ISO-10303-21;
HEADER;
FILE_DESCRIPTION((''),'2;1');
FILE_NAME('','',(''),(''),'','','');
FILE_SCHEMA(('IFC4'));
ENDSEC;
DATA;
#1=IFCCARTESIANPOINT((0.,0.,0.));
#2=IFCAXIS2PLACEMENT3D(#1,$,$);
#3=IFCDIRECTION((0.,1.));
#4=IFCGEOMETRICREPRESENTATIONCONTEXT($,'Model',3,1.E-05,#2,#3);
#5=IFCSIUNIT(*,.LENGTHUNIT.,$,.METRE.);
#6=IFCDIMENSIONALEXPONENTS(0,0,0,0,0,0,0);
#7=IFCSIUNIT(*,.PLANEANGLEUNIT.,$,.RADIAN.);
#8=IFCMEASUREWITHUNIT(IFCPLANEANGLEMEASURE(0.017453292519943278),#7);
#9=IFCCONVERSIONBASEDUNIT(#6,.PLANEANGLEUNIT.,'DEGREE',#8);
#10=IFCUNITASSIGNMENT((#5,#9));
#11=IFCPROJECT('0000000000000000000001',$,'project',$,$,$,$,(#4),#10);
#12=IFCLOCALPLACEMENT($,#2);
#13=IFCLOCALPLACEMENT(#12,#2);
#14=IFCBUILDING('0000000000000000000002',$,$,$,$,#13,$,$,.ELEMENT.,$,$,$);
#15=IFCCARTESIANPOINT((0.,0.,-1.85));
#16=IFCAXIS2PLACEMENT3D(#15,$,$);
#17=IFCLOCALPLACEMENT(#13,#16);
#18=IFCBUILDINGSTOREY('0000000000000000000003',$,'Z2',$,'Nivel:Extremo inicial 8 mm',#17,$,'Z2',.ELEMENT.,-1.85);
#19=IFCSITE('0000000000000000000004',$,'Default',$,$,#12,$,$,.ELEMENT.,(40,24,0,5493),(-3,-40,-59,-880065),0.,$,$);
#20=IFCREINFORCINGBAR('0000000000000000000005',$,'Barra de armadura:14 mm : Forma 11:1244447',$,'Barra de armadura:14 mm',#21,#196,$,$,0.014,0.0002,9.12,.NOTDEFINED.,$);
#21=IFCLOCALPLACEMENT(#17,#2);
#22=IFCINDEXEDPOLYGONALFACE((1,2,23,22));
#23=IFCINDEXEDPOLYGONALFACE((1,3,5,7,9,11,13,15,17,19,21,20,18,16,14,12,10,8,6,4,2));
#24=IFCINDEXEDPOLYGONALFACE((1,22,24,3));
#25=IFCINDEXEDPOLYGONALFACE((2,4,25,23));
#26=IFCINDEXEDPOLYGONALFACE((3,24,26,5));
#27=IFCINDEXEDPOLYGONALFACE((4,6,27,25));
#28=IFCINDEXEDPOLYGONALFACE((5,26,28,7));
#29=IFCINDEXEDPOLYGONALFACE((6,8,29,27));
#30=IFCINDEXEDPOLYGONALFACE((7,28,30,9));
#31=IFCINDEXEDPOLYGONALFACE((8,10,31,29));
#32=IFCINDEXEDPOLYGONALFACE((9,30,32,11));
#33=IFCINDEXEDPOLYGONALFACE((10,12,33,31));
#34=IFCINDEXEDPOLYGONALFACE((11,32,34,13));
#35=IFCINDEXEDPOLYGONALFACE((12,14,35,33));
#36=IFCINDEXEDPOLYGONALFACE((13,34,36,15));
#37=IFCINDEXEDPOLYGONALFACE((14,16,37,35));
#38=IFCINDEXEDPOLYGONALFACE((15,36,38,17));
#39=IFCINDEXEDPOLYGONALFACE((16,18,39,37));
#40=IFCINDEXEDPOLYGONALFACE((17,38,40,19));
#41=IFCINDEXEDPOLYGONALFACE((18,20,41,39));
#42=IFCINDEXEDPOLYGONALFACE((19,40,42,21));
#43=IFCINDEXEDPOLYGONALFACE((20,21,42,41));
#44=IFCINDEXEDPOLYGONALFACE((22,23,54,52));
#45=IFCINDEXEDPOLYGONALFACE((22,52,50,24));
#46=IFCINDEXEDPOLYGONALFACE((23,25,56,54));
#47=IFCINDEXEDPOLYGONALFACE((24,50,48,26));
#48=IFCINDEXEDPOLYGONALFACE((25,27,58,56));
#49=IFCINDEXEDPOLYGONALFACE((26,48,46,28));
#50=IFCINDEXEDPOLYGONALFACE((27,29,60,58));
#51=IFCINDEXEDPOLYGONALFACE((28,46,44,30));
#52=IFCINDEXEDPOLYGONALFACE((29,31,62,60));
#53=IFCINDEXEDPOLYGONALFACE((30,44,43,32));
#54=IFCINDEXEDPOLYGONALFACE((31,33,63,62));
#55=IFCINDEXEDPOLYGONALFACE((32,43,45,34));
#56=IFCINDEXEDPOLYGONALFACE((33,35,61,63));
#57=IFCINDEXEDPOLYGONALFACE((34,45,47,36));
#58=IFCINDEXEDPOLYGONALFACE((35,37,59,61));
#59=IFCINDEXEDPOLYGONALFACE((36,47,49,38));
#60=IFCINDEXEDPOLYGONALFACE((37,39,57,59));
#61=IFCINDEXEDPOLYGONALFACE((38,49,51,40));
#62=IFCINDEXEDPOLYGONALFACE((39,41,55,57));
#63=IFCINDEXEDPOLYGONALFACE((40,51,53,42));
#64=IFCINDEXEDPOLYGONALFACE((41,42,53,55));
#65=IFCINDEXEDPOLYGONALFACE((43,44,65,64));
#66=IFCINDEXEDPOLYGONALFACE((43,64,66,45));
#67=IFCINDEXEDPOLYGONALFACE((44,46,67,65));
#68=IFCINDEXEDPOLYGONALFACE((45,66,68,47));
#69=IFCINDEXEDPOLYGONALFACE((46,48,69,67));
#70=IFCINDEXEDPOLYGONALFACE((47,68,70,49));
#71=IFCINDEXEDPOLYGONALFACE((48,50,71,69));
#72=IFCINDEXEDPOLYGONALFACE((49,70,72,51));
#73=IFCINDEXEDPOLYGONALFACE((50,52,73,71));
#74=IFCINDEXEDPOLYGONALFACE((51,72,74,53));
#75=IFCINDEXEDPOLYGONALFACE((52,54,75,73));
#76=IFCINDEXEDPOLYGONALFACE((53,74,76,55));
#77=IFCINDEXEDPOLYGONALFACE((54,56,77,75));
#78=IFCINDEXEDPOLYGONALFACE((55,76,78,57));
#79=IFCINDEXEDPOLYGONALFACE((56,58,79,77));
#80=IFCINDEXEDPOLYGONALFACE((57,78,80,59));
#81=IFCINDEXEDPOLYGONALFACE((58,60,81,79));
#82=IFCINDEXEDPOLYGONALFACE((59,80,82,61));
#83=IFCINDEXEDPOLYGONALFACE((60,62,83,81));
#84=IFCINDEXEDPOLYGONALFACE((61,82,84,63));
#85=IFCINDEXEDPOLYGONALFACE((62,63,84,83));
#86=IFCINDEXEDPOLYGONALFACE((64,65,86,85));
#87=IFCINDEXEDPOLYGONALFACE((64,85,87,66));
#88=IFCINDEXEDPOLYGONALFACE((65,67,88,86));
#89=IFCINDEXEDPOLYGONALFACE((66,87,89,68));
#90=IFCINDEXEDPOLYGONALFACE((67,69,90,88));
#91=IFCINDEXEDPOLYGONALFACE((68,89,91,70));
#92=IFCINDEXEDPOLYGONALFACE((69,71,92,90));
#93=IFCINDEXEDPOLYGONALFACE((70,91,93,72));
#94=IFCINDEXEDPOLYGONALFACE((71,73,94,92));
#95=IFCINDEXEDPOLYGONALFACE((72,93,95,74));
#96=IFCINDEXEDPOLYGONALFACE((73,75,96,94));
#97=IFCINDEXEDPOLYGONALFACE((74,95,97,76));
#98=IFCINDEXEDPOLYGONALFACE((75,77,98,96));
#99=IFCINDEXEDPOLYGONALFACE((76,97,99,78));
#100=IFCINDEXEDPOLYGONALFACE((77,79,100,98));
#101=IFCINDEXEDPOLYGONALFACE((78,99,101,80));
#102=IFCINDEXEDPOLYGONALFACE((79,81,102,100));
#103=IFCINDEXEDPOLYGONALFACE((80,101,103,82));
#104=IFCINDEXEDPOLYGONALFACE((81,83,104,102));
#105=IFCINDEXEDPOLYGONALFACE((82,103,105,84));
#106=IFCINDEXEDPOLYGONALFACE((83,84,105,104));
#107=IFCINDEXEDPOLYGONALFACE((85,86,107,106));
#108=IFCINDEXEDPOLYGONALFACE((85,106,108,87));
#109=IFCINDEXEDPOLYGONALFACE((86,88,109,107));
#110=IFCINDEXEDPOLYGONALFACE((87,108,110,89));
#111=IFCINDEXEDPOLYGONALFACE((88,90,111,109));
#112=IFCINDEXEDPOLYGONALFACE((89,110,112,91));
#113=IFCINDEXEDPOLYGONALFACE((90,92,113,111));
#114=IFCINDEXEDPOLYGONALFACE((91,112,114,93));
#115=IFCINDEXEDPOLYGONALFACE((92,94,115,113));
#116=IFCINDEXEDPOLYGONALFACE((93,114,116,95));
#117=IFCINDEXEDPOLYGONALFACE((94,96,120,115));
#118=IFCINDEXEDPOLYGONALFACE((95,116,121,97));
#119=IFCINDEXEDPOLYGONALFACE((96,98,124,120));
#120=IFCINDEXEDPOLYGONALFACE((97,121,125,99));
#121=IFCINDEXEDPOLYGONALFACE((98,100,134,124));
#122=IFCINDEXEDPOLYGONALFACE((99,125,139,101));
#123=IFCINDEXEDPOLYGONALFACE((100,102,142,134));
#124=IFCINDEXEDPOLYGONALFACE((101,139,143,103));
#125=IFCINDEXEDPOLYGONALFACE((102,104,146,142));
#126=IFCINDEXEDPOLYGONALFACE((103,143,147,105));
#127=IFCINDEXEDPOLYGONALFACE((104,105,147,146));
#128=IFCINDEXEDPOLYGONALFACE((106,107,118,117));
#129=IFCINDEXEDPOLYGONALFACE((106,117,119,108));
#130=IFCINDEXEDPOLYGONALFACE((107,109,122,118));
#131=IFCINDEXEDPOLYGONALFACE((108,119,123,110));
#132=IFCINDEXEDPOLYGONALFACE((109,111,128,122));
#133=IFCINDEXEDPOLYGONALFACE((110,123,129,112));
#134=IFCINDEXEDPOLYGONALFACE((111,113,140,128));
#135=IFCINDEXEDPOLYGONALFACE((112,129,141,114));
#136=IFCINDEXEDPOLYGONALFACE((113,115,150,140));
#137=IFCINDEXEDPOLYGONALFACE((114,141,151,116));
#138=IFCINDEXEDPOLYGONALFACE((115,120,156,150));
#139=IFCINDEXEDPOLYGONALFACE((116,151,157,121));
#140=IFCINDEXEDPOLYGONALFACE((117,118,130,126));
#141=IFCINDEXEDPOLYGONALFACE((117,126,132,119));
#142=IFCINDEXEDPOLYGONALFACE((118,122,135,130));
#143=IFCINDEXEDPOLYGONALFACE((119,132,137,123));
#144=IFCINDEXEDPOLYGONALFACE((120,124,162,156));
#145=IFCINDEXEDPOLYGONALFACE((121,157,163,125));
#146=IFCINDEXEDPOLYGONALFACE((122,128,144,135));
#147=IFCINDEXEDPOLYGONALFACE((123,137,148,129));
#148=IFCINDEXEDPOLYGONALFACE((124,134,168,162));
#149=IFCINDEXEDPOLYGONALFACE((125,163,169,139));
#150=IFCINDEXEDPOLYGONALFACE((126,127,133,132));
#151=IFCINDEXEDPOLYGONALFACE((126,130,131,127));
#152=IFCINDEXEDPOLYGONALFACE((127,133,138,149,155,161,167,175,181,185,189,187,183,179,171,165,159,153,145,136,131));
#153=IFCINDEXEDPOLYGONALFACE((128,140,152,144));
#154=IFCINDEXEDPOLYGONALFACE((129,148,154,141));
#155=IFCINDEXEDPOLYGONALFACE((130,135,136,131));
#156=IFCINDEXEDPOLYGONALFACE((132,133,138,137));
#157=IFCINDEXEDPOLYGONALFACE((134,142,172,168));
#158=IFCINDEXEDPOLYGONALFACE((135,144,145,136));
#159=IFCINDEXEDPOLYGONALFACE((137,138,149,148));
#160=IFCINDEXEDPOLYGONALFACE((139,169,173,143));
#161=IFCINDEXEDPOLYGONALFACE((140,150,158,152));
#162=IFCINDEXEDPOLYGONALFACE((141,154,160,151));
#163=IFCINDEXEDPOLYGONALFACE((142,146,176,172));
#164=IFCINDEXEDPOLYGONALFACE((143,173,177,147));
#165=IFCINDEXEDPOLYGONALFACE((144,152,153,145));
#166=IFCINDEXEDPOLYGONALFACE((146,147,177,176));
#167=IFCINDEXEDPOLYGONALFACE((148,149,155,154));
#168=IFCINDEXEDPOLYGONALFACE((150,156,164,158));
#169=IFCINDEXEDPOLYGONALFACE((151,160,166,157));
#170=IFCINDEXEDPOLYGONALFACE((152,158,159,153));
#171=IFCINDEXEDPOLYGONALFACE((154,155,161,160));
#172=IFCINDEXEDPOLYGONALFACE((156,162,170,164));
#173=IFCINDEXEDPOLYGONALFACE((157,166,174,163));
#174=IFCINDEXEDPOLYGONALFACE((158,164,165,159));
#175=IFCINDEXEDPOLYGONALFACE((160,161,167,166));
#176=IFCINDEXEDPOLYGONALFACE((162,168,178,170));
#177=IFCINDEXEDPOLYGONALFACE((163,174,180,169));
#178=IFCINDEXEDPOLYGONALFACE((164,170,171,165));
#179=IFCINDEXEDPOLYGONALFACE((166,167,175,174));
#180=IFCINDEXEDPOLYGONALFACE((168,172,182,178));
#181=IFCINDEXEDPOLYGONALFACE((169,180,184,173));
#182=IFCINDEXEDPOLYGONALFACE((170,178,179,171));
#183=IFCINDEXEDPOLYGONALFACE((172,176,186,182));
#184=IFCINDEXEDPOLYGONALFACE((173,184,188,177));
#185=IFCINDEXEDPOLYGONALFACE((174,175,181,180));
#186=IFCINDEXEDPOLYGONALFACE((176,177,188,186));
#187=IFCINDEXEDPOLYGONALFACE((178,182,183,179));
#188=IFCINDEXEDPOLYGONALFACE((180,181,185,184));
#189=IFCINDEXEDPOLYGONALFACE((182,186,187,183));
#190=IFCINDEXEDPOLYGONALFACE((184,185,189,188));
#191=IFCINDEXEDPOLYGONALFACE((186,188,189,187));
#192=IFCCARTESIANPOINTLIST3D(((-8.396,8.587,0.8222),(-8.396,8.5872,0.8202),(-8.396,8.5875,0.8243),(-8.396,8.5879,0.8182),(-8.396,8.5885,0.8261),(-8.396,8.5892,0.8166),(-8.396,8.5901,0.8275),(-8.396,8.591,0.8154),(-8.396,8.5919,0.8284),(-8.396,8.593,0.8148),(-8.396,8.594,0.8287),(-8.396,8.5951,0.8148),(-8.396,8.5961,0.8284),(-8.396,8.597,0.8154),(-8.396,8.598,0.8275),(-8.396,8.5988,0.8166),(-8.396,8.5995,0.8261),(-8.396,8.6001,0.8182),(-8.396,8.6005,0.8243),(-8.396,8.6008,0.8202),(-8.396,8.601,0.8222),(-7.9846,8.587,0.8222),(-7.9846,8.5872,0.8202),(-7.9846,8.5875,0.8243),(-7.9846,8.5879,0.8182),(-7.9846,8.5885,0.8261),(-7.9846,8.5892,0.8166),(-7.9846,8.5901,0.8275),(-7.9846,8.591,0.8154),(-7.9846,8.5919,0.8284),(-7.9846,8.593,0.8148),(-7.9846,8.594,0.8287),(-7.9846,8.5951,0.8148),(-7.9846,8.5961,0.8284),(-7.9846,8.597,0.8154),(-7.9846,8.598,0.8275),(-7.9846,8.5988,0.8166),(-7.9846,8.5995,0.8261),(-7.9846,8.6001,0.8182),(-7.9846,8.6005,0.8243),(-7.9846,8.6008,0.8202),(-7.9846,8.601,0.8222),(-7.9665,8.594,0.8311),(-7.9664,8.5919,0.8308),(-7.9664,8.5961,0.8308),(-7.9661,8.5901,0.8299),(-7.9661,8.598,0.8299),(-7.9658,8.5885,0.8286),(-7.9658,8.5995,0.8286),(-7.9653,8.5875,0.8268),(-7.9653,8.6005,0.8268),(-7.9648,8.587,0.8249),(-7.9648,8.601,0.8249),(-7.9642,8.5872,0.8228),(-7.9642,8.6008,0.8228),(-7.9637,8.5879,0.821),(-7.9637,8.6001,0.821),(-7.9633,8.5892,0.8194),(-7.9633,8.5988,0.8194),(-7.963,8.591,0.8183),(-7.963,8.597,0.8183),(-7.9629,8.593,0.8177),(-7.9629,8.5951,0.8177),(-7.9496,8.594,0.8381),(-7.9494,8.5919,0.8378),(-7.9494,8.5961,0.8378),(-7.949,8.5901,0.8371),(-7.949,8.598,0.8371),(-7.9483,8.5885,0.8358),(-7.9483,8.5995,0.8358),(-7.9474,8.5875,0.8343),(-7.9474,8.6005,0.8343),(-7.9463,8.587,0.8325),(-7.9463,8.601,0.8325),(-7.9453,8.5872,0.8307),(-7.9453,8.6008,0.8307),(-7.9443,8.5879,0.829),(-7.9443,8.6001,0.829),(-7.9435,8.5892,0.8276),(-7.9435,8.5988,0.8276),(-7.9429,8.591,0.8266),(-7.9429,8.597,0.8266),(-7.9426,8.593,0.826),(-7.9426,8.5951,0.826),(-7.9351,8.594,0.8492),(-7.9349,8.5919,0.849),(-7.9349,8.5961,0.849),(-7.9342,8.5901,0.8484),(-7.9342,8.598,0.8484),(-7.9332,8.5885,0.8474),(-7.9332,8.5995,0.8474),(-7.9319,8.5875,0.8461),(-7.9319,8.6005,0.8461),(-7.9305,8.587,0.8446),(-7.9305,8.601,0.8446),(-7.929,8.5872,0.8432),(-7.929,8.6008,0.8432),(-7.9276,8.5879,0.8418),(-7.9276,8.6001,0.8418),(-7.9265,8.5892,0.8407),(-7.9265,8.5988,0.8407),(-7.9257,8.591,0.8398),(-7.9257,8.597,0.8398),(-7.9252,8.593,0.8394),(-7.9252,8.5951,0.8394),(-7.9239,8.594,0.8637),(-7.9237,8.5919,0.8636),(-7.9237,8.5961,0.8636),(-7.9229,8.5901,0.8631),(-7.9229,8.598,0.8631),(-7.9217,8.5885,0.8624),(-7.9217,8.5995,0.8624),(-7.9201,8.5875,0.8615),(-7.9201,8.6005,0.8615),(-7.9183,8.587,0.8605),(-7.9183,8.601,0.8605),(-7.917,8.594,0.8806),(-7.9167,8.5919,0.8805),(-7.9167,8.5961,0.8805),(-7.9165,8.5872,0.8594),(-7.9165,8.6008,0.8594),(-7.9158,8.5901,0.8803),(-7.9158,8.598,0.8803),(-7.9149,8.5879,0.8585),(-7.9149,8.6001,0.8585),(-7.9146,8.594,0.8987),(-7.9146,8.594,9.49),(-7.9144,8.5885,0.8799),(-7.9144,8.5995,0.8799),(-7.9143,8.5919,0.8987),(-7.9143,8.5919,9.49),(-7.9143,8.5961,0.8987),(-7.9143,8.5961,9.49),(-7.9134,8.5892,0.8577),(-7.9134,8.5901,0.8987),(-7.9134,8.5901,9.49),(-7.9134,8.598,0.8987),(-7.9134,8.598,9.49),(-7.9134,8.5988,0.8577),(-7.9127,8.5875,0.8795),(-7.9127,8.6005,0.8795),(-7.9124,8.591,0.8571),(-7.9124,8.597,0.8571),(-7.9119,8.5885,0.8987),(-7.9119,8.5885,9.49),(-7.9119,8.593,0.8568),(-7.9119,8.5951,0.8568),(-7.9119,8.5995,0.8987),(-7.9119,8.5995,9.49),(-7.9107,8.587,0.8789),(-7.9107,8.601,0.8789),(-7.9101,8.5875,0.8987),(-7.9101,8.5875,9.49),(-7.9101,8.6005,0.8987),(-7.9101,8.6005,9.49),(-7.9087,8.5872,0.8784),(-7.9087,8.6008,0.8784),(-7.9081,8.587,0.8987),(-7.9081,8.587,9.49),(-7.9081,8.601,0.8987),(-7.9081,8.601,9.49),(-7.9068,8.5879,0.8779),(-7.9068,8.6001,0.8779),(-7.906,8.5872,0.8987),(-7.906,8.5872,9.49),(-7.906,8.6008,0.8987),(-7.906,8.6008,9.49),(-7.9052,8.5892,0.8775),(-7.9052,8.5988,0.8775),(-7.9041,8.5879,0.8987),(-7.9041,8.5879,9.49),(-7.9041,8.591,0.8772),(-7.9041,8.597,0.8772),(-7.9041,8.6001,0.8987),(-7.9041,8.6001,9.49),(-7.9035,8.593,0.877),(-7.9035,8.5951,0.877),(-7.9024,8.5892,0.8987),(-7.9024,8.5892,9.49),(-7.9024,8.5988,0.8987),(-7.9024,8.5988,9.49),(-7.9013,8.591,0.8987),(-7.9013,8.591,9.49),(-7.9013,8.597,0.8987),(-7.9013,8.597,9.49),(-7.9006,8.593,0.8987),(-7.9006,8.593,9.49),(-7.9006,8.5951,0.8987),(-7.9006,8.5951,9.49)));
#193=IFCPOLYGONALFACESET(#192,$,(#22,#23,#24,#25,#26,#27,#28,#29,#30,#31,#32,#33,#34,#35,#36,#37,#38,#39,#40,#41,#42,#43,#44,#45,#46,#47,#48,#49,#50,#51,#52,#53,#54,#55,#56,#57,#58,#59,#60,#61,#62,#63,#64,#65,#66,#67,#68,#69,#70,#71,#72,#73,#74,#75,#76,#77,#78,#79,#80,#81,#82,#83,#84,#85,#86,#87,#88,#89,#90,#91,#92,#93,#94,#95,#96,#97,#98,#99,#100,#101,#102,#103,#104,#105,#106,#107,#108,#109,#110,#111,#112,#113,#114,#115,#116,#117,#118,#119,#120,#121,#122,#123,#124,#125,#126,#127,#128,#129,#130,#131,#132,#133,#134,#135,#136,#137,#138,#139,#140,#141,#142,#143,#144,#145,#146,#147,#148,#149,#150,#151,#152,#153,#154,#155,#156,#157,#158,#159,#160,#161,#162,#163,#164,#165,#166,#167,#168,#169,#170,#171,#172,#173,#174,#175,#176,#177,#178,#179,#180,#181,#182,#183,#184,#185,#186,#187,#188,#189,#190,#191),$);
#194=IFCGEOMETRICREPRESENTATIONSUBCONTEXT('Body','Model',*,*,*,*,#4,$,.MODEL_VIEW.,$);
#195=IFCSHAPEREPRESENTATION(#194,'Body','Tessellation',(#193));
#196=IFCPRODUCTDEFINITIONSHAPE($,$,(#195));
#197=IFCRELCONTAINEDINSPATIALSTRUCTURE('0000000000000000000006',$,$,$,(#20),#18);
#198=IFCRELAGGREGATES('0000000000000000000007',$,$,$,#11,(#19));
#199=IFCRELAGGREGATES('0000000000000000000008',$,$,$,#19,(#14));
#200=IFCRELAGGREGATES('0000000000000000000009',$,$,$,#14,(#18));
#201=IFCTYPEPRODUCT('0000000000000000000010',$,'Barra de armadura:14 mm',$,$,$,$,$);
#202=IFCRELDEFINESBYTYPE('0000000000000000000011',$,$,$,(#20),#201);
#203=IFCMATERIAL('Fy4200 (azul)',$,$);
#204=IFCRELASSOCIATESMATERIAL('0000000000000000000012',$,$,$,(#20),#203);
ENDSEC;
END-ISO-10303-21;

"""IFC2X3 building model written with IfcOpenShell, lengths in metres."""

from ifc_helpers import new_model, entity, si_unit, converted_unit, direction, frame, origin, place, context, subcontext, project, spatial, material, type_object, element, save


model = new_model("IFC2X3")

# Units and contexts
model_context = context("Model", 3, precision=1e-05, world=origin(), true_north=direction((0.0, 1.0)))
body_context = subcontext(model_context, "Body", "Model", "MODEL_VIEW")
ifc_project = project(units=[si_unit("LENGTHUNIT", "METRE"), converted_unit("PLANEANGLEUNIT", "DEGREE", entity("IfcPlaneAngleMeasure", 0.017453292519943278), si_unit("PLANEANGLEUNIT", "RADIAN"), dimensions=[0, 0, 0, 0, 0, 0, 0])], contexts=[model_context])

# Site, building, storey
site_placement = place(None, origin())
site = spatial("IfcSite", under=ifc_project, at=site_placement, Name="Default", CompositionType="ELEMENT", RefLatitude=(40, 24, 0, 5493), RefLongitude=(-3, -40, -59, -880065), RefElevation=0.0)
building_placement = place(site_placement, origin())
building = spatial("IfcBuilding", under=site, at=building_placement, CompositionType="ELEMENT")
storey_placement = place(building_placement, frame((0.0, 0.0, -1.85)))
storey = spatial("IfcBuildingStorey", under=building, at=storey_placement, Name="Z2", ObjectType="Nivel:Extremo inicial 8 mm", LongName="Z2", CompositionType="ELEMENT", Elevation=-1.85)

# Reinforcing bar
ifc_material_1 = material(Name="Fy4200 (azul)")
type_product_1 = type_object("IfcTypeProduct", Name="Barra de armadura:14 mm")
reinforcing_bar_1_placement = place(storey_placement, origin())
element("IfcReinforcingBar", 1, at=reinforcing_bar_1_placement, inside=storey, type_object=type_product_1, material=ifc_material_1, Name="Barra de armadura:14 mm : Forma 11:1244447", ObjectType="Barra de armadura:14 mm", BarLength=9.12, BarRole="NOTDEFINED", CrossSectionArea=0.0002, NominalDiameter=0.014, context=body_context, shape_type="AdvancedSweptSolid", body=[
    entity("IfcSweptDiskSolid", entity("IfcCompositeCurve", [entity("IfcCompositeCurveSegment", "CONTINUOUS", True, entity("IfcPolyline", [entity("IfcCartesianPoint", [-7.9076, 8.594, 9.49]), entity("IfcCartesianPoint", [-7.9076, 8.594, 0.8987])])), entity("IfcCompositeCurveSegment", "CONTINUOUS", True, entity("IfcTrimmedCurve", entity("IfcCircle", entity("IfcAxis2Placement3D", entity("IfcCartesianPoint", [-7.9846, 8.594, 0.8987]), entity("IfcDirection", [0.0, 1.0, 0.0]), entity("IfcDirection", [0.0, 0.0, -1.0])), 0.077), [entity("IfcParameterValue", 270.0)], [entity("IfcParameterValue", 360.0)], True, "PARAMETER")), entity("IfcCompositeCurveSegment", "CONTINUOUS", True, entity("IfcPolyline", [entity("IfcCartesianPoint", [-7.9846, 8.594, 0.8217]), entity("IfcCartesianPoint", [-8.396, 8.594, 0.8217])]))], False), 0.007, None, 0.0, 92.0),
])

save(model, "model.ifc")
